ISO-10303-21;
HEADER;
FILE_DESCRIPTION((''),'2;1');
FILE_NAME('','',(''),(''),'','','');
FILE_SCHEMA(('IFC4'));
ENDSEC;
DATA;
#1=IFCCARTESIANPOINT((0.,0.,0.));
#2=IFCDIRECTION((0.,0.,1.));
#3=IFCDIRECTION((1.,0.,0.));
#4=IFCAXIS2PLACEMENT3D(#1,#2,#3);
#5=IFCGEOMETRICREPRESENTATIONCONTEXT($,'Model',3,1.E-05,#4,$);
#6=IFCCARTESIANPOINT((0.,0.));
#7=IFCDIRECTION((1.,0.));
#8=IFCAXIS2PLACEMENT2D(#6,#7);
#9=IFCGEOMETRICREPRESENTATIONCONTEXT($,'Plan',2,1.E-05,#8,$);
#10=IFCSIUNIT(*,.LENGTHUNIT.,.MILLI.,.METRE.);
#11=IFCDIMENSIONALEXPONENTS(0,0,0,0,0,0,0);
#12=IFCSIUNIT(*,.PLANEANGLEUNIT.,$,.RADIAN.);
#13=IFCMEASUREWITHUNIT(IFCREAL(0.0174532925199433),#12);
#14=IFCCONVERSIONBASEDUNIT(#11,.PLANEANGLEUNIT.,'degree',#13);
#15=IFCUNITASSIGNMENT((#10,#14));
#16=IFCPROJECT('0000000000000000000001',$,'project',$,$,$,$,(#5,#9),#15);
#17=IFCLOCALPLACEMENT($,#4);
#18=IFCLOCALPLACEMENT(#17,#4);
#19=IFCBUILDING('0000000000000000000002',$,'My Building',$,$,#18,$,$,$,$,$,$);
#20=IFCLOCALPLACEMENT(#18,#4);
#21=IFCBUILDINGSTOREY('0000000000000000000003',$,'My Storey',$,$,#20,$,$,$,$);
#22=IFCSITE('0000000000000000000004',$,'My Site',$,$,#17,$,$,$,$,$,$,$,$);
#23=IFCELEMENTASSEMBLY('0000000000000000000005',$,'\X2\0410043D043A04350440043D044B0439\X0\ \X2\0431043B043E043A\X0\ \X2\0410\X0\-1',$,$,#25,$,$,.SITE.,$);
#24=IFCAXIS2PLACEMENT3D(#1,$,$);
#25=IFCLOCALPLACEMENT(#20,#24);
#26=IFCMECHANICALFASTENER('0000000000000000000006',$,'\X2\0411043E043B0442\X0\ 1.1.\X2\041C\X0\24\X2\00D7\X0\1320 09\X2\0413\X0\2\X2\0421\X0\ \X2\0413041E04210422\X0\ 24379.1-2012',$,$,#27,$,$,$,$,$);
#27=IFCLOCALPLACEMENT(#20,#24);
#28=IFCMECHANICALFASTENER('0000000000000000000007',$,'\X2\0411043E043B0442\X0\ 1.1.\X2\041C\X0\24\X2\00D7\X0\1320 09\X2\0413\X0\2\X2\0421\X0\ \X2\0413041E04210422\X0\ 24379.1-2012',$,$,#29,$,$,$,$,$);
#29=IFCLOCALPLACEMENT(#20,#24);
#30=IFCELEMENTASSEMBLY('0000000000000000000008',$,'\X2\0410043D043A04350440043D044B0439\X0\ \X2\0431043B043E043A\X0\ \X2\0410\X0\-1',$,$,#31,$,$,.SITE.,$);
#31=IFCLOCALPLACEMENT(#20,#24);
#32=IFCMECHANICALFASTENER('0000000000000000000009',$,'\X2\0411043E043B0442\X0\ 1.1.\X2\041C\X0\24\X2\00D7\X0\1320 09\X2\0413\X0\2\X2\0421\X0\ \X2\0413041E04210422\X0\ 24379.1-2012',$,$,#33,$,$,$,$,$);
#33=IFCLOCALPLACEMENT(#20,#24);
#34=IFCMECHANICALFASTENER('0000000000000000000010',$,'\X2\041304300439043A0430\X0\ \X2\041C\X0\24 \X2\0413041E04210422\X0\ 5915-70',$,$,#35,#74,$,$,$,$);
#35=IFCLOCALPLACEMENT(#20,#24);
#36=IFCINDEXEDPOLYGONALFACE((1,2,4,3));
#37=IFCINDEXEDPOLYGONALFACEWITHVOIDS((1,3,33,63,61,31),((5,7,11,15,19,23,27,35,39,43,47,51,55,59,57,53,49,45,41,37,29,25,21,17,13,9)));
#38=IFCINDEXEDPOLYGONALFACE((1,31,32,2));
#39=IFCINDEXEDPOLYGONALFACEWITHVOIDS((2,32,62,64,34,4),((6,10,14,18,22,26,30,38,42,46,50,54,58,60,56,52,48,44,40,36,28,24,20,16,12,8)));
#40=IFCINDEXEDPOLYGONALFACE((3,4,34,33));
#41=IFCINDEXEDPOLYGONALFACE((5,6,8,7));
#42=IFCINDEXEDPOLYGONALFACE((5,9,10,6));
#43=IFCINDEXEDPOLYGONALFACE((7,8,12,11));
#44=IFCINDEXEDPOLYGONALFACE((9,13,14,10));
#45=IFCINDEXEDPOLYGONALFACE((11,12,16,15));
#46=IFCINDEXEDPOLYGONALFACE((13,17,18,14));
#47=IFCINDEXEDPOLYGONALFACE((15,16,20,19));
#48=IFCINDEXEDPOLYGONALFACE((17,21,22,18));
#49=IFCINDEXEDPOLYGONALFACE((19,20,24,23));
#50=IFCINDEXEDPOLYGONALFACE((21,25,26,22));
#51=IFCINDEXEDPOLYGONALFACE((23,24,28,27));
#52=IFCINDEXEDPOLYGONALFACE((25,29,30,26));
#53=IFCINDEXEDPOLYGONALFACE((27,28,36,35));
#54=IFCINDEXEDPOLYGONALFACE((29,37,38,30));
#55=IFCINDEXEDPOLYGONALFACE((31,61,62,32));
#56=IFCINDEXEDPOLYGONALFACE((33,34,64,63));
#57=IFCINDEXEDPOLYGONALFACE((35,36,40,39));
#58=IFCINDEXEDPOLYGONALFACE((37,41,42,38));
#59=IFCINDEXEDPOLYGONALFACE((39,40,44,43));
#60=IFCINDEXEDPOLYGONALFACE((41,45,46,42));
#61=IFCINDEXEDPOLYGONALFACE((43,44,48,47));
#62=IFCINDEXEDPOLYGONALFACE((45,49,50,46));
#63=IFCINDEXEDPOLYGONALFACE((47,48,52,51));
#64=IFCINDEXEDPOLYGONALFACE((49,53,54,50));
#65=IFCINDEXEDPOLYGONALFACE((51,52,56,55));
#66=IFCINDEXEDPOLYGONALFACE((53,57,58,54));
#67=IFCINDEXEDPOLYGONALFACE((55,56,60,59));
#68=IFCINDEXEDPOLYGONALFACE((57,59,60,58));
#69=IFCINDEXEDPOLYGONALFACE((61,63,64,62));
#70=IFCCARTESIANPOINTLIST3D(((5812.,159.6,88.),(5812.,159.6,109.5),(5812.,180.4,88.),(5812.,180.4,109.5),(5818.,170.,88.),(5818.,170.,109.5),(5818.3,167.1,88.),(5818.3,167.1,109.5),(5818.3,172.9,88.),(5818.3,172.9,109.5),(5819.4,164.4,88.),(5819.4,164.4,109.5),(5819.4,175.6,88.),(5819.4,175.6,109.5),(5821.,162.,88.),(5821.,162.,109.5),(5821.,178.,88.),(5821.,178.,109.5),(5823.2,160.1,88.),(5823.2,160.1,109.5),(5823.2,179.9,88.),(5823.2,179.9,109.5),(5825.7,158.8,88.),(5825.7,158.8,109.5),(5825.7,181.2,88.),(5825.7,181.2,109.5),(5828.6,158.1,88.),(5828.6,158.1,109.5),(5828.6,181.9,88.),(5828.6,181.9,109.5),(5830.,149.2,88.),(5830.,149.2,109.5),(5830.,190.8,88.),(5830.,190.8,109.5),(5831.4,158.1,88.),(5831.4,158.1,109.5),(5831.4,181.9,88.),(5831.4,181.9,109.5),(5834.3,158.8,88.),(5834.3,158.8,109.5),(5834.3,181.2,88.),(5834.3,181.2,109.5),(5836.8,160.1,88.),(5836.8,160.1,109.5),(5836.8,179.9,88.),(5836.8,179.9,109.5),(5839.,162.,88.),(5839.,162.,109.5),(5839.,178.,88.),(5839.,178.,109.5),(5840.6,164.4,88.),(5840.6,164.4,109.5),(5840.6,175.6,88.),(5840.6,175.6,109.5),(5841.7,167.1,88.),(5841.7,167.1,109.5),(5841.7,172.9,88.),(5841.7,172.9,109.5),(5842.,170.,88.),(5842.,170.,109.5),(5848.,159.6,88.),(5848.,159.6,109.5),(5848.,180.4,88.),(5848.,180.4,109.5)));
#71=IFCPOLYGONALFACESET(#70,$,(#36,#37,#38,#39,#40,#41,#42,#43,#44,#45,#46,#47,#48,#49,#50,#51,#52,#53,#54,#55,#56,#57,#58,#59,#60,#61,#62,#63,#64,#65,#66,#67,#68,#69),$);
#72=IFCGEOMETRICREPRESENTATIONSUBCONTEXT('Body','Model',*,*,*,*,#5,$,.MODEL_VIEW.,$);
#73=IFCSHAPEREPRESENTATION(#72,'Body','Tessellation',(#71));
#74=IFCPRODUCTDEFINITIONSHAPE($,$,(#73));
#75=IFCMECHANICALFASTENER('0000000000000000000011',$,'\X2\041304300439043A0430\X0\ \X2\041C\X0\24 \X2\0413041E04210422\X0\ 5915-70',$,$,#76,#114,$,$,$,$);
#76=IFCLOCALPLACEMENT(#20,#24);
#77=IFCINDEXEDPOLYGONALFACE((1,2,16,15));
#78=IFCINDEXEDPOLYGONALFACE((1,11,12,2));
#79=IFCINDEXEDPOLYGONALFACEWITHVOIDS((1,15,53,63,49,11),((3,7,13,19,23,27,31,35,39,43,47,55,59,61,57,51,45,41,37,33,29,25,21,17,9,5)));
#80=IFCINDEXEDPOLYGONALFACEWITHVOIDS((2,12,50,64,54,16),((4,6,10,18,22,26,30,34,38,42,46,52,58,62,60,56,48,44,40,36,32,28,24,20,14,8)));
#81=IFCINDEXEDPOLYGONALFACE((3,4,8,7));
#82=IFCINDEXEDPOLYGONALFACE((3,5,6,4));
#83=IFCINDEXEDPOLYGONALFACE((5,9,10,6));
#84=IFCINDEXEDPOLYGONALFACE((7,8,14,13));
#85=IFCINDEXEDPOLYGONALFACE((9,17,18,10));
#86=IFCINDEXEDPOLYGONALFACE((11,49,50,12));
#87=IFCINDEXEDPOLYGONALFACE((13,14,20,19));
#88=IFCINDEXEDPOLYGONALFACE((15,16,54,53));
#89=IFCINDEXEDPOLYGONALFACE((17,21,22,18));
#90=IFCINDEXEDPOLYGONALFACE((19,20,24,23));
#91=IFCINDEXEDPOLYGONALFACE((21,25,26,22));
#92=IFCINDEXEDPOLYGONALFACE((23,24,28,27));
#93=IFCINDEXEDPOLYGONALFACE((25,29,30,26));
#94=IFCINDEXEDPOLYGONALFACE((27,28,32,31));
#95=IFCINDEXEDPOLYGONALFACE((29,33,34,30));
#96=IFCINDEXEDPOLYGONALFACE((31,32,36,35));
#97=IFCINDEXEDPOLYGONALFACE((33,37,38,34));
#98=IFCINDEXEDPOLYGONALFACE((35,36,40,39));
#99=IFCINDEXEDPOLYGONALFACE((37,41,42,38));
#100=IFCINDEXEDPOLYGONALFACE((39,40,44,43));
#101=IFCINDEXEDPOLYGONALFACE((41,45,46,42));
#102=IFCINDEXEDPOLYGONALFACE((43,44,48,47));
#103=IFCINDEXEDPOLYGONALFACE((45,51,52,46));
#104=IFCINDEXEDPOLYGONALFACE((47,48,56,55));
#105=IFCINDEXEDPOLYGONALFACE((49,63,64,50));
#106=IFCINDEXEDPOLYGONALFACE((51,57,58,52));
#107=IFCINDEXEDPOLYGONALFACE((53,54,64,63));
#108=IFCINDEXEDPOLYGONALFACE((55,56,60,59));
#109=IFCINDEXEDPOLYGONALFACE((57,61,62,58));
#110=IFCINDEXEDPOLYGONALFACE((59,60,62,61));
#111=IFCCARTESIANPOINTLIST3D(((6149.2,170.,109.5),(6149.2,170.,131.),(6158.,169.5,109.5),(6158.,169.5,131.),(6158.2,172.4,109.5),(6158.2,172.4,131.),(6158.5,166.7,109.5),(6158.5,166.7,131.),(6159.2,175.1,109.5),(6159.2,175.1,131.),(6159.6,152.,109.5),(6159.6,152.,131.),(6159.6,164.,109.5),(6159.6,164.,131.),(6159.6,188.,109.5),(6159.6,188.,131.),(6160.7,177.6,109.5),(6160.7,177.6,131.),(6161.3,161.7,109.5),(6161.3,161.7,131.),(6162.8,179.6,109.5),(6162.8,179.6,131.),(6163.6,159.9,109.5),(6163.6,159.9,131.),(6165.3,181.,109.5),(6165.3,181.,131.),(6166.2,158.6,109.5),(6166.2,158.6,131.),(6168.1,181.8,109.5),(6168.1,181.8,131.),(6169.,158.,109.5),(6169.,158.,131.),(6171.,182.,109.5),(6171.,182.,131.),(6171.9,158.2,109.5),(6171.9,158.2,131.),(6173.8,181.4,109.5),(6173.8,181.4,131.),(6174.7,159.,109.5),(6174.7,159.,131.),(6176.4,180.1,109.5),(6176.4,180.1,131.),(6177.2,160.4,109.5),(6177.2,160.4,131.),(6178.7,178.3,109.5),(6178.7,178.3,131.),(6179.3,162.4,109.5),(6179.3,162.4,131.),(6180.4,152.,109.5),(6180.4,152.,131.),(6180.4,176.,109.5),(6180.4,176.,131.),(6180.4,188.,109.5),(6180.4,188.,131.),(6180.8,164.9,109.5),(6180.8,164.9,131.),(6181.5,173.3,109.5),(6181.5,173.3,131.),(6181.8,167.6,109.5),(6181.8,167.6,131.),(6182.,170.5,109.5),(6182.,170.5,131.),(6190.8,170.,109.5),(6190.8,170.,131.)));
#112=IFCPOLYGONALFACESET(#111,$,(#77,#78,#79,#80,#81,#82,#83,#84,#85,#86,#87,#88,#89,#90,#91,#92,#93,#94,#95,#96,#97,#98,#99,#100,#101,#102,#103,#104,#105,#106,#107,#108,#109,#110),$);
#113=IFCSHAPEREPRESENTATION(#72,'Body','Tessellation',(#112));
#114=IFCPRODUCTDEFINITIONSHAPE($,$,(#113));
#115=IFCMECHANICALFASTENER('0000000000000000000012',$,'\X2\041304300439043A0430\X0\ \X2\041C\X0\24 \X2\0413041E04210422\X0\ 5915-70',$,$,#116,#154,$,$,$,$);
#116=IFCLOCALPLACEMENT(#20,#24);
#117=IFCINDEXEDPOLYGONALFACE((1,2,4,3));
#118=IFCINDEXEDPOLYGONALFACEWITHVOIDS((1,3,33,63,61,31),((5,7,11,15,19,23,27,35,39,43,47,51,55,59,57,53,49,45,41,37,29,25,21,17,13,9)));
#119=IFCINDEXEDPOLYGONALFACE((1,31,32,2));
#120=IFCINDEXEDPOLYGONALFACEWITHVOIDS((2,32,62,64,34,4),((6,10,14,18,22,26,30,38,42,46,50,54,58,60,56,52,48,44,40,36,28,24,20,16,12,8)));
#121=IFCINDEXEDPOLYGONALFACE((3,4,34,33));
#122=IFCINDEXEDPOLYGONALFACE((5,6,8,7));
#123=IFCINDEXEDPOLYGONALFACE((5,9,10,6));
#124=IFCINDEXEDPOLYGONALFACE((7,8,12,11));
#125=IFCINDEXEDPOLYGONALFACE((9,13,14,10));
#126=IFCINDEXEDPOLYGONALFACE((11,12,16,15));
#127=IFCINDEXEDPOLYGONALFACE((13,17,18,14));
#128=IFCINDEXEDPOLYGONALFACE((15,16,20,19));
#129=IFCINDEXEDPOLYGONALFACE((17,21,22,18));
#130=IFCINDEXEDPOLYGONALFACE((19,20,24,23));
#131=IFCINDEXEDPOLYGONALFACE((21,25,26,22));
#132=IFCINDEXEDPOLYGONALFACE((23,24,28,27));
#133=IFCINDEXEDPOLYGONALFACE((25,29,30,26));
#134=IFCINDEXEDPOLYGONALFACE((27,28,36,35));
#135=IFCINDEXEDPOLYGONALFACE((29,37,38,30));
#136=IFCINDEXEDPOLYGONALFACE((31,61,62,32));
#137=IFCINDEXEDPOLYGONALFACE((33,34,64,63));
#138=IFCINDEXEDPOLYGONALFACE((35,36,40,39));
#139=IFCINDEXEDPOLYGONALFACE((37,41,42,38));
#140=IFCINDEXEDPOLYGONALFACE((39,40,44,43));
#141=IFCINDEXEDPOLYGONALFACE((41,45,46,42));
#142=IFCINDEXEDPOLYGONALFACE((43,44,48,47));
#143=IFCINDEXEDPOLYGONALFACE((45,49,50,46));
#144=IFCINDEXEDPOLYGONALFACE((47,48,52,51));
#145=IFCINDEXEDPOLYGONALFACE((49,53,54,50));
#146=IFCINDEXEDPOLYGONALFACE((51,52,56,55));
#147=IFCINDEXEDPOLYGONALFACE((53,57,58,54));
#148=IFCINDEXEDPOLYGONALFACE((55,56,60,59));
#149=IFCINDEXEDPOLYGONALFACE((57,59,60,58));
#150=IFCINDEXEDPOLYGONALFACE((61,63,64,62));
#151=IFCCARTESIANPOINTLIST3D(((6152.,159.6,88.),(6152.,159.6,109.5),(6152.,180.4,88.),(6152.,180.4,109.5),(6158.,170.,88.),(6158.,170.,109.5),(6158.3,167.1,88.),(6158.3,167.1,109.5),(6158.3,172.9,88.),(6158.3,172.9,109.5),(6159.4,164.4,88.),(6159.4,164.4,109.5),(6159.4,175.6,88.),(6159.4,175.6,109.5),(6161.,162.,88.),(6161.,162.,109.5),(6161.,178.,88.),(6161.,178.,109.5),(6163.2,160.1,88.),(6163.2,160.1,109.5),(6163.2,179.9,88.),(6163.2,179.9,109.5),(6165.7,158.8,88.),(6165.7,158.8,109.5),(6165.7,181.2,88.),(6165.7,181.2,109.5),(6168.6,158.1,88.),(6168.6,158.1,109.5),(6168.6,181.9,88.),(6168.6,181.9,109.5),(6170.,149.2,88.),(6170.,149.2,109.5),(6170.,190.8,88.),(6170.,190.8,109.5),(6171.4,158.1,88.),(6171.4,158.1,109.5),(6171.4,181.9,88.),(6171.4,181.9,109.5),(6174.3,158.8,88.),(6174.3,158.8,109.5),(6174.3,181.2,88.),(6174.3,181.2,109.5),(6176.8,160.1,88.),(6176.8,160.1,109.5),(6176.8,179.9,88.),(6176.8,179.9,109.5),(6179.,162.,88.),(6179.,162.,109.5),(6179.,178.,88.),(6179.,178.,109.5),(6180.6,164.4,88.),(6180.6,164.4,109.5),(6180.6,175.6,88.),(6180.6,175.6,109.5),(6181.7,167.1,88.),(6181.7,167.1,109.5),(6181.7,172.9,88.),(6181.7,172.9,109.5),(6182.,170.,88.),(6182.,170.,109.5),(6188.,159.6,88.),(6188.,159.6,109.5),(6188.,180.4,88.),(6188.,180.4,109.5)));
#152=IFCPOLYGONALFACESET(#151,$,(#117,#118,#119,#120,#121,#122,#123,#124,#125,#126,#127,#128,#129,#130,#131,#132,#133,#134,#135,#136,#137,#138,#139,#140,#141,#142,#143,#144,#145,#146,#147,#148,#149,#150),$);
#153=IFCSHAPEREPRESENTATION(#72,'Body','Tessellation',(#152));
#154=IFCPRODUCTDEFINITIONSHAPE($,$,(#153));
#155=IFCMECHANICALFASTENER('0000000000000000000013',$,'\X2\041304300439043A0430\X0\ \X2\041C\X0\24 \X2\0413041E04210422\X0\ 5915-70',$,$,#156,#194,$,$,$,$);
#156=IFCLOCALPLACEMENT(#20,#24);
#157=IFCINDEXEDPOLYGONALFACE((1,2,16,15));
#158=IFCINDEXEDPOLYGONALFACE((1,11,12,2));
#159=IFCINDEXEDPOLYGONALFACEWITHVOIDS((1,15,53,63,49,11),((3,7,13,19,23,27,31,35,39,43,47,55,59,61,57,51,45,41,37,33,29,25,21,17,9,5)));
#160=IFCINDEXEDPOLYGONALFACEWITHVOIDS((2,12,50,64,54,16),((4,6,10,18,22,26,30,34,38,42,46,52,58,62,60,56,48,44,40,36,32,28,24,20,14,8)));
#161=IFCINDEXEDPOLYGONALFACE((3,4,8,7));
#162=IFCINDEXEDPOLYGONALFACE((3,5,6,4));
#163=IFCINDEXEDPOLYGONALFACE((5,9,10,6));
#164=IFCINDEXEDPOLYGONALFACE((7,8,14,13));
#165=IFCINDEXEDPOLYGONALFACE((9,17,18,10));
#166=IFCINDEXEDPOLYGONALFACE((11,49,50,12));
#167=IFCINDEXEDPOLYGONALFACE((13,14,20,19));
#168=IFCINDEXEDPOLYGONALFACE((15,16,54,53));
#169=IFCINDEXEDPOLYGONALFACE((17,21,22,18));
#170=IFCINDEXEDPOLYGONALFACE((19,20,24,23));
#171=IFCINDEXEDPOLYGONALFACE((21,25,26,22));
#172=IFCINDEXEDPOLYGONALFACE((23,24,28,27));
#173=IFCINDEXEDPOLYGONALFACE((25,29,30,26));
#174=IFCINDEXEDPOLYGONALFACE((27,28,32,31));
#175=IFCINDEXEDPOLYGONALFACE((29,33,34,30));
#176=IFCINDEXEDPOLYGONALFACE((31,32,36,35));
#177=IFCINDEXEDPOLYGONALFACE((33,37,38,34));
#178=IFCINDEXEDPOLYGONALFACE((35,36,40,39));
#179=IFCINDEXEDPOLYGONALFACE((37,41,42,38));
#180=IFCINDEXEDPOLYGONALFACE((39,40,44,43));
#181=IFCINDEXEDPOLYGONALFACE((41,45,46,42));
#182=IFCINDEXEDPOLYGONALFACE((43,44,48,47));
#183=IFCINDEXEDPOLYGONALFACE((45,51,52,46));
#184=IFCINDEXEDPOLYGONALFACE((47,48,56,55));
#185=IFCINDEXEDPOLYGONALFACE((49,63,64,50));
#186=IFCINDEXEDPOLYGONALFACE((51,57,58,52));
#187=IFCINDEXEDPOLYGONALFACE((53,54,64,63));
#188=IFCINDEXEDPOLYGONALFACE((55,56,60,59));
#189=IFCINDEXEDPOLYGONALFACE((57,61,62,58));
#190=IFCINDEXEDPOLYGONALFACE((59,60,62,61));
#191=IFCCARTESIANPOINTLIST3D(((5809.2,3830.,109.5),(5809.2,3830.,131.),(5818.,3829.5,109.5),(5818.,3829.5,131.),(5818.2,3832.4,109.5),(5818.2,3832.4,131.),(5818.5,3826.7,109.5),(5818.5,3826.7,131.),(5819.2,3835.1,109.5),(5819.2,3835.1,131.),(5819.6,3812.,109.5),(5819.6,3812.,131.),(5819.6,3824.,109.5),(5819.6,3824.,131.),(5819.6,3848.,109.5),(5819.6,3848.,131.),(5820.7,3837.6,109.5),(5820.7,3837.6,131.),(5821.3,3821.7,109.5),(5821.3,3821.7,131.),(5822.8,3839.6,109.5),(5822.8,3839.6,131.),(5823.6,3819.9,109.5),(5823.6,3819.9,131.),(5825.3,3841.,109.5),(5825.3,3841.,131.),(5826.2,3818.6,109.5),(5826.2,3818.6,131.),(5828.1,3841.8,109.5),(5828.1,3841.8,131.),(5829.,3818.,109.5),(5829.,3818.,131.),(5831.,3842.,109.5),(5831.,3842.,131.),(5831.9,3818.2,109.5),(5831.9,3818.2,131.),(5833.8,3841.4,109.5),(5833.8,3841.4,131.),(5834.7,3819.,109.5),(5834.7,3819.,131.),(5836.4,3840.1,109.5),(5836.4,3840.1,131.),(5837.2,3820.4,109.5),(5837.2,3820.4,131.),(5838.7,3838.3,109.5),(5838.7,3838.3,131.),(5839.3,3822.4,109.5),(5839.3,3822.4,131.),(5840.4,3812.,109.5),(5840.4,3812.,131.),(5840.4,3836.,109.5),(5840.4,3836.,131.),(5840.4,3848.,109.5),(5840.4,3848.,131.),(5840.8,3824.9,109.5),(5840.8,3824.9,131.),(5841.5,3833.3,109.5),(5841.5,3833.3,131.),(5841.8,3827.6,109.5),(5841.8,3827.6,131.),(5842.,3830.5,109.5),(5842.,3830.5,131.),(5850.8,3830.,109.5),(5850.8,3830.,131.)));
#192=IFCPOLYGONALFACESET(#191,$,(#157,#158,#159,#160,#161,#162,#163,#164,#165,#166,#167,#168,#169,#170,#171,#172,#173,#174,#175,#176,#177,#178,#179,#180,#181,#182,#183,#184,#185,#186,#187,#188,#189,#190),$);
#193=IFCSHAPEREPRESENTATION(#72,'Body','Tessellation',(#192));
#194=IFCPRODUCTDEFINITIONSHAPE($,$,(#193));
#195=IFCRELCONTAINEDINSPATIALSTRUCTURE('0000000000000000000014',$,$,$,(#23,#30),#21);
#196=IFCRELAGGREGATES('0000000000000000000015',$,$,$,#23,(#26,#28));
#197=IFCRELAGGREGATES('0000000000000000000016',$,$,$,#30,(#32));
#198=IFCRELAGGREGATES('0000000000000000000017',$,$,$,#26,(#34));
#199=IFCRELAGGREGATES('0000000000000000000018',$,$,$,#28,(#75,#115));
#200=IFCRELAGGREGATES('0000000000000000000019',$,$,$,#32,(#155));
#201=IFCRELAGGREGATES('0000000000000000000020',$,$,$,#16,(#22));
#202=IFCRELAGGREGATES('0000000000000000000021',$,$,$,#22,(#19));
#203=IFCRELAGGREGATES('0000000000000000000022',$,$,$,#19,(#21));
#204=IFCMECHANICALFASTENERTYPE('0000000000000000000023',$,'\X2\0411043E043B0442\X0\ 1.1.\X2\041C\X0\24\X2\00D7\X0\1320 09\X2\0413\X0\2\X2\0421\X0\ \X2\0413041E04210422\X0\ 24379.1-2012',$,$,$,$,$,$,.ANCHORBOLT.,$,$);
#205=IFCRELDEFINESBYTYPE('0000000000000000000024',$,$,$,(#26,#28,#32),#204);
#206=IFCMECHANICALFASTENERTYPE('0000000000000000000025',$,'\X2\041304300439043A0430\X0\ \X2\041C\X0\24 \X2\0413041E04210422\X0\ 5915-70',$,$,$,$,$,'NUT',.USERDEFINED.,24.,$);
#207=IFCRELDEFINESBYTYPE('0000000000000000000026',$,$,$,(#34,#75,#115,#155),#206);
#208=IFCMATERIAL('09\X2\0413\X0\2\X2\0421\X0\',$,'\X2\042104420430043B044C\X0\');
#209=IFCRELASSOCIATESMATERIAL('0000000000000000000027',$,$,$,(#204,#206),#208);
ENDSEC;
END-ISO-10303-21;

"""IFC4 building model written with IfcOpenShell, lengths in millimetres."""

from ifc_helpers import new_model, entity, si_unit, converted_unit, frame, origin_with_axes, origin_2d_with_axis, place, context, subcontext, project, spatial, polyline, outline, extrude, source, transform, mapped, material, type_object, type_shapes, element, aggregate, save


model = new_model("IFC4")

# Units and contexts
model_context = context("Model", 3, precision=1e-05, world=origin_with_axes())
plan_context = context("Plan", 2, precision=1e-05, world=origin_2d_with_axis())
body_context = subcontext(model_context, "Body", "Model", "MODEL_VIEW")
ifc_project = project(units=[si_unit("LENGTHUNIT", "METRE", prefix="MILLI"), converted_unit("PLANEANGLEUNIT", "degree", entity("IfcReal", 0.0174532925199433), si_unit("PLANEANGLEUNIT", "RADIAN"), dimensions=[0, 0, 0, 0, 0, 0, 0])], contexts=[model_context, plan_context])

# Site, building, storey
site_placement = place(None, origin_with_axes())
site = spatial("IfcSite", under=ifc_project, at=site_placement, Name="My Site")
building_placement = place(site_placement, origin_with_axes())
building = spatial("IfcBuilding", under=site, at=building_placement, Name="My Building")
storey_placement = place(building_placement, origin_with_axes())
storey = spatial("IfcBuildingStorey", under=building, at=storey_placement, Name="My Storey")

# Element assemblies, mechanical fasteners
assembly_1_placement = place(storey_placement, frame((6000.0, 0.0, 0.0), z_axis=(0.0, 0.0, 1.0), x_axis=(1.0, 0.0, 0.0)))
assembly_1 = element("IfcElementAssembly", 1, at=assembly_1_placement, inside=storey, Name="Анкерный блок А-1", AssemblyPlace="SITE")
ifc_material_1 = material(Name="09Г2С", Category="Сталь")
mechanical_fastener_type_1 = type_object("IfcMechanicalFastenerType", Name="Болт 1.1.М24×1320 09Г2С ГОСТ 24379.1-2012", PredefinedType="ANCHORBOLT", material=ifc_material_1)
mechanical_fastener_1_placement = place(assembly_1_placement, frame((-170.0, 170.0, 0.0), z_axis=(0.0, 0.0, 1.0), x_axis=(-1.0, 0.0, 0.0)))
mechanical_fastener_1 = element("IfcMechanicalFastener", 2, at=mechanical_fastener_1_placement, type_object=mechanical_fastener_type_1, Name="Болт 1.1.М24×1320 09Г2С ГОСТ 24379.1-2012")
mechanical_fastener_2_placement = place(assembly_1_placement, frame((170.0, 170.0, 0.0), z_axis=(0.0, 0.0, 1.0), x_axis=(-1.0, 0.0, 0.0)))
mechanical_fastener_2 = element("IfcMechanicalFastener", 3, at=mechanical_fastener_2_placement, type_object=mechanical_fastener_type_1, Name="Болт 1.1.М24×1320 09Г2С ГОСТ 24379.1-2012")
aggregate(assembly_1, [mechanical_fastener_1, mechanical_fastener_2])
assembly_2_placement = place(storey_placement, frame((6000.0, 4000.0, 0.0), z_axis=(0.0, 0.0, 1.0), x_axis=(1.0, 0.0, 0.0)))
assembly_2 = element("IfcElementAssembly", 4, at=assembly_2_placement, inside=storey, Name="Анкерный блок А-1", AssemblyPlace="SITE")
mechanical_fastener_3_placement = place(assembly_2_placement, frame((-170.0, -170.0, 0.0), z_axis=(0.0, 0.0, 1.0), x_axis=(1.0, 0.0, 0.0)))
mechanical_fastener_3 = element("IfcMechanicalFastener", 5, at=mechanical_fastener_3_placement, type_object=mechanical_fastener_type_1, Name="Болт 1.1.М24×1320 09Г2С ГОСТ 24379.1-2012")
aggregate(assembly_2, [mechanical_fastener_3])

# Mechanical fasteners
mechanical_fastener_type_2 = type_object("IfcMechanicalFastenerType", Name="Гайка М24 ГОСТ 5915-70", ElementType="NUT", NominalDiameter=24.0, PredefinedType="USERDEFINED", material=ifc_material_1)
shared_shape_1 = source(origin_with_axes(), body_context, "Body", "SweptSolid", [
    extrude(outline(polyline([(-10.4, -18.0), (10.4, -18.0), (20.8, 0.0), (10.4, 18.0), (-10.4, 18.0), (-20.8, 0.0), (-10.4, -18.0)]), holes=[polyline([(-8.0, 9.0), (-5.6, 10.6), (-2.9, 11.7), (0.0, 12.0), (2.9, 11.7), (5.6, 10.6), (8.0, 9.0), (9.9, 6.8), (11.2, 4.3), (11.9, 1.4), (11.9, -1.4), (11.2, -4.3), (9.9, -6.8), (8.0, -9.0), (5.6, -10.6), (2.9, -11.7), (0.0, -12.0), (-2.9, -11.7), (-5.6, -10.6), (-8.0, -9.0), (-9.9, -6.8), (-11.2, -4.3), (-11.9, -1.4), (-11.9, 1.4), (-11.2, 4.3), (-9.9, 6.8), (-8.0, 9.0)])]), frame((0.0, 0.0, 0.0), z_axis=(0.0, 0.0, 1.0), x_axis=(0.0, 1.0, 0.0)), (0.0, 0.0, 1.0), 21.5),
])
type_shapes(mechanical_fastener_type_2, [shared_shape_1])
mechanical_fastener_4_placement = place(mechanical_fastener_1_placement, frame((0.0, 0.0, 88.0), z_axis=(0.0, 0.0, 1.0), x_axis=(1.0, 0.0, 0.0)))
mechanical_fastener_4 = element("IfcMechanicalFastener", 6, at=mechanical_fastener_4_placement, type_object=mechanical_fastener_type_2, Name="Гайка М24 ГОСТ 5915-70", context=body_context, shape_type="MappedRepresentation", body=[
    mapped(shared_shape_1, transform((0.0, 0.0, 0.0), x_axis=(1.0, 0.0, 0.0), y_axis=(0.0, 1.0, 0.0), z_axis=(0.0, 0.0, 1.0), scale=1.0)),
])
mechanical_fastener_5_placement = place(mechanical_fastener_2_placement, frame((0.0, 0.0, 109.5), z_axis=(0.0, 0.0, 1.0), x_axis=(0.866025, 0.5, 0.0)))
mechanical_fastener_5 = element("IfcMechanicalFastener", 7, at=mechanical_fastener_5_placement, type_object=mechanical_fastener_type_2, Name="Гайка М24 ГОСТ 5915-70", context=body_context, shape_type="MappedRepresentation", body=[
    mapped(shared_shape_1, transform((0.0, 0.0, 0.0), x_axis=(1.0, 0.0, 0.0), y_axis=(0.0, 1.0, 0.0), z_axis=(0.0, 0.0, 1.0), scale=1.0)),
])
mechanical_fastener_6_placement = place(mechanical_fastener_2_placement, frame((0.0, 0.0, 88.0), z_axis=(0.0, 0.0, 1.0), x_axis=(1.0, 0.0, 0.0)))
mechanical_fastener_6 = element("IfcMechanicalFastener", 8, at=mechanical_fastener_6_placement, type_object=mechanical_fastener_type_2, Name="Гайка М24 ГОСТ 5915-70", context=body_context, shape_type="MappedRepresentation", body=[
    mapped(shared_shape_1, transform((0.0, 0.0, 0.0), x_axis=(1.0, 0.0, 0.0), y_axis=(0.0, 1.0, 0.0), z_axis=(0.0, 0.0, 1.0), scale=1.0)),
])
mechanical_fastener_7_placement = place(mechanical_fastener_3_placement, frame((0.0, 0.0, 109.5), z_axis=(0.0, 0.0, 1.0), x_axis=(0.866025, 0.5, 0.0)))
mechanical_fastener_7 = element("IfcMechanicalFastener", 9, at=mechanical_fastener_7_placement, type_object=mechanical_fastener_type_2, Name="Гайка М24 ГОСТ 5915-70", context=body_context, shape_type="MappedRepresentation", body=[
    mapped(shared_shape_1, transform((0.0, 0.0, 0.0), x_axis=(1.0, 0.0, 0.0), y_axis=(0.0, 1.0, 0.0), z_axis=(0.0, 0.0, 1.0), scale=1.0)),
])
aggregate(mechanical_fastener_1, [mechanical_fastener_4])
aggregate(mechanical_fastener_2, [mechanical_fastener_5, mechanical_fastener_6])
aggregate(mechanical_fastener_3, [mechanical_fastener_7])

save(model, "model.ifc")
